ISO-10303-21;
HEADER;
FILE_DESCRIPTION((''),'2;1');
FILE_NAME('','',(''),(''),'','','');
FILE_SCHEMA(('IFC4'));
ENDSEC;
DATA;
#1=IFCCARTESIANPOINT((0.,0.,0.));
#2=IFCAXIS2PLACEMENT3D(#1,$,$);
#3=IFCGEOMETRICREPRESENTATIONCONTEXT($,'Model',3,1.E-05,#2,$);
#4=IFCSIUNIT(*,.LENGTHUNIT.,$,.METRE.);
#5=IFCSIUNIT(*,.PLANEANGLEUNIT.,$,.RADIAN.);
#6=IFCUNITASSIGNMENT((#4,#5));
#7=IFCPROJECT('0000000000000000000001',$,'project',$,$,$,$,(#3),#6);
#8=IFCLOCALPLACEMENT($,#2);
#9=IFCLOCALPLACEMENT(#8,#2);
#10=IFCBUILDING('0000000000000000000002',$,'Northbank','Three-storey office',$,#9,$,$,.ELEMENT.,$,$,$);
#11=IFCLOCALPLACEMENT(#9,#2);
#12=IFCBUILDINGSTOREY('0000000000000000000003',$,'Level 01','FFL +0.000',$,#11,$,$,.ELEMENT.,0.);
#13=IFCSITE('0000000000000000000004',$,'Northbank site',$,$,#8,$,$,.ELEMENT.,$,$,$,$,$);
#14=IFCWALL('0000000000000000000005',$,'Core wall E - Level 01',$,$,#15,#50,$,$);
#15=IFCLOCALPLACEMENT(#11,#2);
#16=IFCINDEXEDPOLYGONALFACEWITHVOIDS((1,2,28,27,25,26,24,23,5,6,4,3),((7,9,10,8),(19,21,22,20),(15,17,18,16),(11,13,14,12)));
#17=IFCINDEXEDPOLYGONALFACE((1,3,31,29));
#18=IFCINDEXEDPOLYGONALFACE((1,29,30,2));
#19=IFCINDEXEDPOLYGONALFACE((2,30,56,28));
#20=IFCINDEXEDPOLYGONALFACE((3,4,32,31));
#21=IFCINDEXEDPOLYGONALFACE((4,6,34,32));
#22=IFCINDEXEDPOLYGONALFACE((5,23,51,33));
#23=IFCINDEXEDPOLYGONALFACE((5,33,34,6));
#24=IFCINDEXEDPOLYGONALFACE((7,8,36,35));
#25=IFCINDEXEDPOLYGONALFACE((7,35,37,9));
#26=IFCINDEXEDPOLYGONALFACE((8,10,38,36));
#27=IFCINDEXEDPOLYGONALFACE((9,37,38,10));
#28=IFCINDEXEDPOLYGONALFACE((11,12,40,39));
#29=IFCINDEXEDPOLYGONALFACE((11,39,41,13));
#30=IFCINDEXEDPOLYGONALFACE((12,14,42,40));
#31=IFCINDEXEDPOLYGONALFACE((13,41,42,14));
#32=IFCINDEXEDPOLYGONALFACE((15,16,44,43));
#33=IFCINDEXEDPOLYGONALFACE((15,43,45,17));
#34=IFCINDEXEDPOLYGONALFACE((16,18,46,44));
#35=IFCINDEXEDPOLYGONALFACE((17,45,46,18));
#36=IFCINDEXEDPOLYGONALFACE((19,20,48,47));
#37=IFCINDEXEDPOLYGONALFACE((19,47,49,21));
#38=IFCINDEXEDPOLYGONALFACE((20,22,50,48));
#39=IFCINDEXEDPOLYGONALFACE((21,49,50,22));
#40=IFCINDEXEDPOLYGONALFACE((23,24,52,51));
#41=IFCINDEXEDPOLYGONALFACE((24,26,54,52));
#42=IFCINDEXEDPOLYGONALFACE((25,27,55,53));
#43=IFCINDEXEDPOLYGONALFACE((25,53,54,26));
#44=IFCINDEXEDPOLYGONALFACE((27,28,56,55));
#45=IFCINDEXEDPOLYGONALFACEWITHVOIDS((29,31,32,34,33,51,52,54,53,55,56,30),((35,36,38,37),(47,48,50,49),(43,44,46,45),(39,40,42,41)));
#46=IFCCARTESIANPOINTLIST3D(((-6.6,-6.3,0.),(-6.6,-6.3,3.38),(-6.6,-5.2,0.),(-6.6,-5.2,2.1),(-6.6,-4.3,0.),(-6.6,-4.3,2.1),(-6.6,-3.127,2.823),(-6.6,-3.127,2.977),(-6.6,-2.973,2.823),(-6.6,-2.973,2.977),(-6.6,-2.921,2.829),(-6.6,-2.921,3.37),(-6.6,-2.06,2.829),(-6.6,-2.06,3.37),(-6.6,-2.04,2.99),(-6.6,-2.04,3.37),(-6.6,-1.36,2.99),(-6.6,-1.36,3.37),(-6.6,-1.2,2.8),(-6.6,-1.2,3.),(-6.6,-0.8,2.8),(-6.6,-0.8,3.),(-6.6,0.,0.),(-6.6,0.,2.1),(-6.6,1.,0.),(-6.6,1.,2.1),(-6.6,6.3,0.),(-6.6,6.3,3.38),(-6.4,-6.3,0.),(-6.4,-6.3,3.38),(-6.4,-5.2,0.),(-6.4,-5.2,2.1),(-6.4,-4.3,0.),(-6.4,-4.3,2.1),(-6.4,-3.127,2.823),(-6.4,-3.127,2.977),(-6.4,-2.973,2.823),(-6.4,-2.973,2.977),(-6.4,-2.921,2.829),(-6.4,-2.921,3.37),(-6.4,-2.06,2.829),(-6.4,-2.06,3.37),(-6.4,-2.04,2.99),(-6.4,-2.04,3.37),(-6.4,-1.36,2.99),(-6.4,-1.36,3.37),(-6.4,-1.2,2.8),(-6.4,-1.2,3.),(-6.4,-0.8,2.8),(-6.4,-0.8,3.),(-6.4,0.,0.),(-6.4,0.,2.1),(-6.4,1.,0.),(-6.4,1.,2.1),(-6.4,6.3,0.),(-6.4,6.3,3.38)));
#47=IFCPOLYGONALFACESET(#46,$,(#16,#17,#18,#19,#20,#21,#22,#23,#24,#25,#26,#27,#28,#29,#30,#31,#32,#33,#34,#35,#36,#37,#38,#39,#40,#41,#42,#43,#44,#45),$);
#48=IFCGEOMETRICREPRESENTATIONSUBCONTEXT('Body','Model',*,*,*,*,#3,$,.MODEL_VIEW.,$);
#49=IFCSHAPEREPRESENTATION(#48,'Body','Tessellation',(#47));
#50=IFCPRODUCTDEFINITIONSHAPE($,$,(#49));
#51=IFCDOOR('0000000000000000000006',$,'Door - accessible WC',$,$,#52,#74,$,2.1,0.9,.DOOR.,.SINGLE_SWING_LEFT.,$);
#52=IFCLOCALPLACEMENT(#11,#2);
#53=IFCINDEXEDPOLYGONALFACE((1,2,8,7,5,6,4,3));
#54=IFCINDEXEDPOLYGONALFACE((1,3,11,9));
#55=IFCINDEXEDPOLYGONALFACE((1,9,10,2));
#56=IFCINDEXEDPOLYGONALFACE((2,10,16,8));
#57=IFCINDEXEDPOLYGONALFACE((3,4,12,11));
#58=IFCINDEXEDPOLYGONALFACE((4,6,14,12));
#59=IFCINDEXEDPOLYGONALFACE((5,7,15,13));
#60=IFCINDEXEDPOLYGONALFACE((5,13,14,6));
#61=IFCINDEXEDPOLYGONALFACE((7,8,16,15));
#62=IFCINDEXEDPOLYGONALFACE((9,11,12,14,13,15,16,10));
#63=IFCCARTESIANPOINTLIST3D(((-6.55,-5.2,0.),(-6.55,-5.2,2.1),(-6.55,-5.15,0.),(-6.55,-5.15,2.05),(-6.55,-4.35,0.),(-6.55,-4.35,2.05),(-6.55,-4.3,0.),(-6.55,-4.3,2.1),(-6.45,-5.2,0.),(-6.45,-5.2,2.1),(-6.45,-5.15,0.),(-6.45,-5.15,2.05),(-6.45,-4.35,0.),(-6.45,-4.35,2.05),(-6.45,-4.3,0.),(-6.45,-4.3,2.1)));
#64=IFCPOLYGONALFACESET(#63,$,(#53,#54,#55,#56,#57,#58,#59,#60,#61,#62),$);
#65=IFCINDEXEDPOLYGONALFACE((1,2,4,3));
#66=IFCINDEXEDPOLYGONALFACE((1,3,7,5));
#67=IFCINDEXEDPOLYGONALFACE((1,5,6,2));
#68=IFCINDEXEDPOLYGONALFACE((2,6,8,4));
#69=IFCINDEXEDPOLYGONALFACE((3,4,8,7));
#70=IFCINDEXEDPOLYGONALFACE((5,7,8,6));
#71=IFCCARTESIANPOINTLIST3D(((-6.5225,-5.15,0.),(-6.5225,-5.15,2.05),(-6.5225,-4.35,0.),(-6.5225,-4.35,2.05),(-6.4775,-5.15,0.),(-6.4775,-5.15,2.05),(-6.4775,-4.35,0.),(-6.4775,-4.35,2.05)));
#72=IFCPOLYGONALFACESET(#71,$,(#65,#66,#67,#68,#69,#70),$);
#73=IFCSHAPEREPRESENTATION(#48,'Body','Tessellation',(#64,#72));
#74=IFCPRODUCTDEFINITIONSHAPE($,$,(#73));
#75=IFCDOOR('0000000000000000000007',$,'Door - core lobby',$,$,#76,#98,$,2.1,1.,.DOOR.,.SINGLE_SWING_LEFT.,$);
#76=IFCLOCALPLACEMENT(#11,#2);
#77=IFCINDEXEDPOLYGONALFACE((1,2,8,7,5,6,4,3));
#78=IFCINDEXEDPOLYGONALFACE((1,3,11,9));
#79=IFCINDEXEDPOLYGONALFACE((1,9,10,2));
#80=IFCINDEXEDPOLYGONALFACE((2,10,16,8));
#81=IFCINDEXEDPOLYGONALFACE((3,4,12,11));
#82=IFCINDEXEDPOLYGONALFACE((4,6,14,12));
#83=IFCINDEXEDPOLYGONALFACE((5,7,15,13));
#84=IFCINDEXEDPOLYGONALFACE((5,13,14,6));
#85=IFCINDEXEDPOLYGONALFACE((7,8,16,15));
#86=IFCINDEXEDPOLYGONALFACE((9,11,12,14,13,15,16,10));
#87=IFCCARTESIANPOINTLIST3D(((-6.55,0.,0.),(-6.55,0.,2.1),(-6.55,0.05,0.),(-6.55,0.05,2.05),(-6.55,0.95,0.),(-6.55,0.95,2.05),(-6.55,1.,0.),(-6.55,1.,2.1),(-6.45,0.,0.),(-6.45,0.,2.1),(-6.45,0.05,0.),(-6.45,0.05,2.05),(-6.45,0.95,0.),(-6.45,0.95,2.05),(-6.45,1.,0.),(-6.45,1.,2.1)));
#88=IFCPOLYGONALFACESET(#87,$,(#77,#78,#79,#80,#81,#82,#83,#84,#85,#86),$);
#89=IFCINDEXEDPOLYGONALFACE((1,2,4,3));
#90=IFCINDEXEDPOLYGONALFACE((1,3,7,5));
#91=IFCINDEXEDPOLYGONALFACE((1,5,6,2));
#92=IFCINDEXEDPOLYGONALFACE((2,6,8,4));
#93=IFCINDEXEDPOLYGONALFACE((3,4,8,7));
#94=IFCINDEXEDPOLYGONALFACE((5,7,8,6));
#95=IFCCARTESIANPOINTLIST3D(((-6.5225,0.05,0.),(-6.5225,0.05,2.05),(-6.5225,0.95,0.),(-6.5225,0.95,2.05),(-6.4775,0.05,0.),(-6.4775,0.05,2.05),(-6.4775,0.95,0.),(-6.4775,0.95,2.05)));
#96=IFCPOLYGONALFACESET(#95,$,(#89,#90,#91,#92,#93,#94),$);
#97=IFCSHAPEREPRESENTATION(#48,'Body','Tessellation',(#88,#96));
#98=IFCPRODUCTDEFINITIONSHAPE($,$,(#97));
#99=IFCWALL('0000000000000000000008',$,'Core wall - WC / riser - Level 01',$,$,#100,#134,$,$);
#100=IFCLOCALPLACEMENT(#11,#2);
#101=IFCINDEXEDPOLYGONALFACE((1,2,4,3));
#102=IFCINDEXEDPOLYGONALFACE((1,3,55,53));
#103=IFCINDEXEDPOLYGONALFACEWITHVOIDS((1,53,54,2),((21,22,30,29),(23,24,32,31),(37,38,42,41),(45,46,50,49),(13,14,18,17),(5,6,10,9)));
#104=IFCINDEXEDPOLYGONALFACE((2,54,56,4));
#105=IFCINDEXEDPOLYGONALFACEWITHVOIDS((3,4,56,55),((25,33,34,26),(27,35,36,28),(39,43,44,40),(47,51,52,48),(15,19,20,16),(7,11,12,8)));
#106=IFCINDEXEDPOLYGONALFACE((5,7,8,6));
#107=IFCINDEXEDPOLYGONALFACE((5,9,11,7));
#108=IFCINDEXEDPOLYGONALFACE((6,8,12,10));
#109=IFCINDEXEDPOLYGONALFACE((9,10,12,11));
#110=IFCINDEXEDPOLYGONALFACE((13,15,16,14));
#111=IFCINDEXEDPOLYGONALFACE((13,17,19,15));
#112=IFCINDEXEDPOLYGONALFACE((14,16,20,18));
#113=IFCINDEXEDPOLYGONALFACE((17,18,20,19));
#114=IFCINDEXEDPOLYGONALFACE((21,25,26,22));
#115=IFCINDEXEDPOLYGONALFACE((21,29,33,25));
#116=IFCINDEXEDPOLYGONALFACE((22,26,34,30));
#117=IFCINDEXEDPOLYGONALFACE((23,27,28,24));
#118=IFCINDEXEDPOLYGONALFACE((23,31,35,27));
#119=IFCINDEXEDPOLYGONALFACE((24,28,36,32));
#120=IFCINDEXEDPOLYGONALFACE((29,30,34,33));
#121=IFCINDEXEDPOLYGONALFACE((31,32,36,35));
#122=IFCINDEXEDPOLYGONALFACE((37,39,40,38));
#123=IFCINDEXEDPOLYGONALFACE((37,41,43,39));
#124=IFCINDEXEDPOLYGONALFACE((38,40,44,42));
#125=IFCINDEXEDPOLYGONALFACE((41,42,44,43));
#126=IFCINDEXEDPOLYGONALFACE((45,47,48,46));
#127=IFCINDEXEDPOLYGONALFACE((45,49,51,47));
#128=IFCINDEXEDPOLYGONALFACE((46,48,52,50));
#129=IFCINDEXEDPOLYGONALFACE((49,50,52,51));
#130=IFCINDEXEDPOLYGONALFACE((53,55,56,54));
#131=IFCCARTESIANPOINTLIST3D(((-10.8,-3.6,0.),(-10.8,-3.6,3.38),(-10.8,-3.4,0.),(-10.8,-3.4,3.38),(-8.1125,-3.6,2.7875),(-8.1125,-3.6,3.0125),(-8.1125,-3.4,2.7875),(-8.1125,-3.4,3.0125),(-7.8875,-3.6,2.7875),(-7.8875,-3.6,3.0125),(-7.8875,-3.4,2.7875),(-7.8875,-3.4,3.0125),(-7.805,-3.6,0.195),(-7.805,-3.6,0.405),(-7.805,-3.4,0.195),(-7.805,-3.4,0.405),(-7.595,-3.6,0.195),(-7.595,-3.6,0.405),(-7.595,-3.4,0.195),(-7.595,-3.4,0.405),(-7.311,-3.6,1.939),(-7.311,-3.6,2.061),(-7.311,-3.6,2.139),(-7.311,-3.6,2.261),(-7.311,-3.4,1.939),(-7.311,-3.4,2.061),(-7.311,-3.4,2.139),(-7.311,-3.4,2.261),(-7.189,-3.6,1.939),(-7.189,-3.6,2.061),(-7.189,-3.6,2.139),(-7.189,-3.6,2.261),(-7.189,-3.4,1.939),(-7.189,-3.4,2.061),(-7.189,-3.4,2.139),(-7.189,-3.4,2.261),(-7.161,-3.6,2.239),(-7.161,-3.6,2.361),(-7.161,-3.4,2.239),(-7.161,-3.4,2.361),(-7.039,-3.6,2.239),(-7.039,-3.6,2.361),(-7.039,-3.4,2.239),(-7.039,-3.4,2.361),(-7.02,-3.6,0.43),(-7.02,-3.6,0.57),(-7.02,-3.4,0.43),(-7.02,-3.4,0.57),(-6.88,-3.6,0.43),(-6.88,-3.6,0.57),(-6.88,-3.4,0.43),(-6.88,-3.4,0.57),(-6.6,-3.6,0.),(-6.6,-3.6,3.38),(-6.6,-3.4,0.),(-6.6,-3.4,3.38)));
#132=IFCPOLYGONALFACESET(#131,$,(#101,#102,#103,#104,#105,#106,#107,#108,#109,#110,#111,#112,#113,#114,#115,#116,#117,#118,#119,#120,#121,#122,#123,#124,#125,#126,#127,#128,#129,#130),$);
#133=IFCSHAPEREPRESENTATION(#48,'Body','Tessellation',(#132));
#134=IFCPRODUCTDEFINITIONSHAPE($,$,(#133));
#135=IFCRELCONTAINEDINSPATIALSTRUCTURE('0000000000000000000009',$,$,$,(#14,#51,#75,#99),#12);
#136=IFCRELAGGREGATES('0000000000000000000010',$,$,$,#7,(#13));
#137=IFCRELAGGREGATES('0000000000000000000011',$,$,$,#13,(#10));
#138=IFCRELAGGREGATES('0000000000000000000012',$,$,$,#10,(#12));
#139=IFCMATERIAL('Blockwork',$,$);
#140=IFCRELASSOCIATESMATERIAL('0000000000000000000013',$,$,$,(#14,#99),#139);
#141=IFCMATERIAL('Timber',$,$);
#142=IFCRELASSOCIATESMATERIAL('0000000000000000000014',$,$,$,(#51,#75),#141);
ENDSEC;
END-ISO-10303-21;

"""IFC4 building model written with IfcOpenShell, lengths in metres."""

from ifc_helpers import new_model, si_unit, frame, origin, place, context, subcontext, project, spatial, polyline, outline, extrude, material, element, fill, save


model = new_model("IFC4")

# Units and contexts
model_context = context("Model", 3, precision=1e-05, world=origin())
body_context = subcontext(model_context, "Body", "Model", "MODEL_VIEW")
ifc_project = project(units=[si_unit("LENGTHUNIT", "METRE"), si_unit("PLANEANGLEUNIT", "RADIAN")], contexts=[model_context])

# Site, building, storey
site_placement = place(None, origin())
site = spatial("IfcSite", under=ifc_project, at=site_placement, Name="Northbank site", CompositionType="ELEMENT")
building_placement = place(site_placement, origin())
building = spatial("IfcBuilding", under=site, at=building_placement, Name="Northbank", Description="Three-storey office", CompositionType="ELEMENT")
storey_placement = place(building_placement, origin())
storey = spatial("IfcBuildingStorey", under=building, at=storey_placement, Name="Level 01", Description="FFL +0.000", CompositionType="ELEMENT", Elevation=0.0)

# Wall, openings, doors
ifc_material_1 = material(Name="Blockwork")
wall_1_placement = place(storey_placement, origin())
wall_1 = element("IfcWall", 1, at=wall_1_placement, inside=storey, material=ifc_material_1, Name="Core wall E - Level 01", context=body_context, shape_type="SweptSolid", body=[
    extrude(outline(polyline([(0.0, 0.0), (1.1, 0.0), (1.1, 2.1), (2.0, 2.1), (2.0, 0.0), (6.3, 0.0), (6.3, 2.1), (7.3, 2.1), (7.3, 0.0), (12.6, 0.0), (12.6, 3.38), (0.0, 3.38), (0.0, 0.0)]), holes=[polyline([(3.379, 2.829), (3.379, 3.37), (4.24, 3.37), (4.24, 2.829), (3.379, 2.829)]), polyline([(4.26, 2.99), (4.26, 3.37), (4.94, 3.37), (4.94, 2.99), (4.26, 2.99)]), polyline([(3.173, 2.823), (3.173, 2.977), (3.327, 2.977), (3.327, 2.823), (3.173, 2.823)]), polyline([(5.1, 2.8), (5.1, 3.0), (5.5, 3.0), (5.5, 2.8), (5.1, 2.8)])]), frame((-6.6, -6.3, 0.0), z_axis=(1.0, 0.0, 0.0), x_axis=(0.0, 1.0, 0.0)), (0.0, 0.0, 1.0), 0.2),
])
opening_1_placement = place(storey_placement, origin())
opening_1 = element("IfcOpeningElement", 2, at=opening_1_placement, cuts=wall_1, PredefinedType="OPENING", context=body_context, shape_type="SweptSolid", body=[
    extrude(outline(polyline([(0.0, 0.0), (0.9, 0.0), (0.9, 2.1), (0.0, 2.1), (0.0, 0.0)])), frame((-6.65, -5.2, 0.0), z_axis=(1.0, 0.0, 0.0), x_axis=(0.0, 1.0, 0.0)), (0.0, 0.0, 1.0), 0.3),
])
opening_2_placement = place(storey_placement, origin())
opening_2 = element("IfcOpeningElement", 3, at=opening_2_placement, cuts=wall_1, PredefinedType="OPENING", context=body_context, shape_type="SweptSolid", body=[
    extrude(outline(polyline([(0.0, 0.0), (1.0, 0.0), (1.0, 2.1), (0.0, 2.1), (0.0, 0.0)])), frame((-6.65, 0.0, 0.0), z_axis=(1.0, 0.0, 0.0), x_axis=(0.0, 1.0, 0.0)), (0.0, 0.0, 1.0), 0.3),
])
ifc_material_2 = material(Name="Timber")
door_1_placement = place(storey_placement, origin())
door_1 = element("IfcDoor", 4, at=door_1_placement, inside=storey, material=ifc_material_2, Name="Door - accessible WC", OperationType="SINGLE_SWING_LEFT", OverallHeight=2.1, OverallWidth=0.9, PredefinedType="DOOR", context=body_context, shape_type="SweptSolid", body=[
    extrude(outline(polyline([(0.0, 0.0), (0.05, 0.0), (0.05, 2.05), (0.85, 2.05), (0.85, 0.0), (0.9, 0.0), (0.9, 2.1), (0.0, 2.1), (0.0, 0.0)])), frame((-6.55, -5.2, 0.0), z_axis=(1.0, 0.0, 0.0), x_axis=(0.0, 1.0, 0.0)), (0.0, 0.0, 1.0), 0.1),
    extrude(outline(polyline([(0.0, 0.0), (0.8, 0.0), (0.8, 2.05), (0.0, 2.05), (0.0, 0.0)])), frame((-6.5225, -5.15, 0.0), z_axis=(1.0, 0.0, 0.0), x_axis=(0.0, 1.0, 0.0)), (0.0, 0.0, 1.0), 0.045),
])
fill(opening_1, door_1)
door_2_placement = place(storey_placement, origin())
door_2 = element("IfcDoor", 5, at=door_2_placement, inside=storey, material=ifc_material_2, Name="Door - core lobby", OperationType="SINGLE_SWING_LEFT", OverallHeight=2.1, OverallWidth=1.0, PredefinedType="DOOR", context=body_context, shape_type="SweptSolid", body=[
    extrude(outline(polyline([(0.0, 0.0), (0.05, 0.0), (0.05, 2.05), (0.95, 2.05), (0.95, 0.0), (1.0, 0.0), (1.0, 2.1), (0.0, 2.1), (0.0, 0.0)])), frame((-6.55, 0.0, 0.0), z_axis=(1.0, 0.0, 0.0), x_axis=(0.0, 1.0, 0.0)), (0.0, 0.0, 1.0), 0.1),
    extrude(outline(polyline([(0.0, 0.0), (0.9, 0.0), (0.9, 2.05), (0.0, 2.05), (0.0, 0.0)])), frame((-6.5225, 0.05, 0.0), z_axis=(1.0, 0.0, 0.0), x_axis=(0.0, 1.0, 0.0)), (0.0, 0.0, 1.0), 0.045),
])
fill(opening_2, door_2)

# Wall
wall_2_placement = place(storey_placement, origin())
element("IfcWall", 6, at=wall_2_placement, inside=storey, material=ifc_material_1, Name="Core wall - WC / riser - Level 01", context=body_context, shape_type="SweptSolid", body=[
    extrude(outline(polyline([(0.0, 0.0), (4.2, 0.0), (4.2, 3.38), (0.0, 3.38), (0.0, 0.0)]), holes=[polyline([(2.6875, 2.7875), (2.6875, 3.0125), (2.9125, 3.0125), (2.9125, 2.7875), (2.6875, 2.7875)]), polyline([(3.489, 1.939), (3.489, 2.061), (3.611, 2.061), (3.611, 1.939), (3.489, 1.939)]), polyline([(3.489, 2.139), (3.489, 2.261), (3.611, 2.261), (3.611, 2.139), (3.489, 2.139)]), polyline([(3.639, 2.239), (3.639, 2.361), (3.761, 2.361), (3.761, 2.239), (3.639, 2.239)]), polyline([(2.995, 0.195), (2.995, 0.405), (3.205, 0.405), (3.205, 0.195), (2.995, 0.195)]), polyline([(3.78, 0.43), (3.78, 0.57), (3.92, 0.57), (3.92, 0.43), (3.78, 0.43)])]), frame((-10.8, -3.4, 0.0), z_axis=(0.0, -1.0, 0.0), x_axis=(1.0, 0.0, 0.0)), (0.0, 0.0, 1.0), 0.2),
])

save(model, "model.ifc")
